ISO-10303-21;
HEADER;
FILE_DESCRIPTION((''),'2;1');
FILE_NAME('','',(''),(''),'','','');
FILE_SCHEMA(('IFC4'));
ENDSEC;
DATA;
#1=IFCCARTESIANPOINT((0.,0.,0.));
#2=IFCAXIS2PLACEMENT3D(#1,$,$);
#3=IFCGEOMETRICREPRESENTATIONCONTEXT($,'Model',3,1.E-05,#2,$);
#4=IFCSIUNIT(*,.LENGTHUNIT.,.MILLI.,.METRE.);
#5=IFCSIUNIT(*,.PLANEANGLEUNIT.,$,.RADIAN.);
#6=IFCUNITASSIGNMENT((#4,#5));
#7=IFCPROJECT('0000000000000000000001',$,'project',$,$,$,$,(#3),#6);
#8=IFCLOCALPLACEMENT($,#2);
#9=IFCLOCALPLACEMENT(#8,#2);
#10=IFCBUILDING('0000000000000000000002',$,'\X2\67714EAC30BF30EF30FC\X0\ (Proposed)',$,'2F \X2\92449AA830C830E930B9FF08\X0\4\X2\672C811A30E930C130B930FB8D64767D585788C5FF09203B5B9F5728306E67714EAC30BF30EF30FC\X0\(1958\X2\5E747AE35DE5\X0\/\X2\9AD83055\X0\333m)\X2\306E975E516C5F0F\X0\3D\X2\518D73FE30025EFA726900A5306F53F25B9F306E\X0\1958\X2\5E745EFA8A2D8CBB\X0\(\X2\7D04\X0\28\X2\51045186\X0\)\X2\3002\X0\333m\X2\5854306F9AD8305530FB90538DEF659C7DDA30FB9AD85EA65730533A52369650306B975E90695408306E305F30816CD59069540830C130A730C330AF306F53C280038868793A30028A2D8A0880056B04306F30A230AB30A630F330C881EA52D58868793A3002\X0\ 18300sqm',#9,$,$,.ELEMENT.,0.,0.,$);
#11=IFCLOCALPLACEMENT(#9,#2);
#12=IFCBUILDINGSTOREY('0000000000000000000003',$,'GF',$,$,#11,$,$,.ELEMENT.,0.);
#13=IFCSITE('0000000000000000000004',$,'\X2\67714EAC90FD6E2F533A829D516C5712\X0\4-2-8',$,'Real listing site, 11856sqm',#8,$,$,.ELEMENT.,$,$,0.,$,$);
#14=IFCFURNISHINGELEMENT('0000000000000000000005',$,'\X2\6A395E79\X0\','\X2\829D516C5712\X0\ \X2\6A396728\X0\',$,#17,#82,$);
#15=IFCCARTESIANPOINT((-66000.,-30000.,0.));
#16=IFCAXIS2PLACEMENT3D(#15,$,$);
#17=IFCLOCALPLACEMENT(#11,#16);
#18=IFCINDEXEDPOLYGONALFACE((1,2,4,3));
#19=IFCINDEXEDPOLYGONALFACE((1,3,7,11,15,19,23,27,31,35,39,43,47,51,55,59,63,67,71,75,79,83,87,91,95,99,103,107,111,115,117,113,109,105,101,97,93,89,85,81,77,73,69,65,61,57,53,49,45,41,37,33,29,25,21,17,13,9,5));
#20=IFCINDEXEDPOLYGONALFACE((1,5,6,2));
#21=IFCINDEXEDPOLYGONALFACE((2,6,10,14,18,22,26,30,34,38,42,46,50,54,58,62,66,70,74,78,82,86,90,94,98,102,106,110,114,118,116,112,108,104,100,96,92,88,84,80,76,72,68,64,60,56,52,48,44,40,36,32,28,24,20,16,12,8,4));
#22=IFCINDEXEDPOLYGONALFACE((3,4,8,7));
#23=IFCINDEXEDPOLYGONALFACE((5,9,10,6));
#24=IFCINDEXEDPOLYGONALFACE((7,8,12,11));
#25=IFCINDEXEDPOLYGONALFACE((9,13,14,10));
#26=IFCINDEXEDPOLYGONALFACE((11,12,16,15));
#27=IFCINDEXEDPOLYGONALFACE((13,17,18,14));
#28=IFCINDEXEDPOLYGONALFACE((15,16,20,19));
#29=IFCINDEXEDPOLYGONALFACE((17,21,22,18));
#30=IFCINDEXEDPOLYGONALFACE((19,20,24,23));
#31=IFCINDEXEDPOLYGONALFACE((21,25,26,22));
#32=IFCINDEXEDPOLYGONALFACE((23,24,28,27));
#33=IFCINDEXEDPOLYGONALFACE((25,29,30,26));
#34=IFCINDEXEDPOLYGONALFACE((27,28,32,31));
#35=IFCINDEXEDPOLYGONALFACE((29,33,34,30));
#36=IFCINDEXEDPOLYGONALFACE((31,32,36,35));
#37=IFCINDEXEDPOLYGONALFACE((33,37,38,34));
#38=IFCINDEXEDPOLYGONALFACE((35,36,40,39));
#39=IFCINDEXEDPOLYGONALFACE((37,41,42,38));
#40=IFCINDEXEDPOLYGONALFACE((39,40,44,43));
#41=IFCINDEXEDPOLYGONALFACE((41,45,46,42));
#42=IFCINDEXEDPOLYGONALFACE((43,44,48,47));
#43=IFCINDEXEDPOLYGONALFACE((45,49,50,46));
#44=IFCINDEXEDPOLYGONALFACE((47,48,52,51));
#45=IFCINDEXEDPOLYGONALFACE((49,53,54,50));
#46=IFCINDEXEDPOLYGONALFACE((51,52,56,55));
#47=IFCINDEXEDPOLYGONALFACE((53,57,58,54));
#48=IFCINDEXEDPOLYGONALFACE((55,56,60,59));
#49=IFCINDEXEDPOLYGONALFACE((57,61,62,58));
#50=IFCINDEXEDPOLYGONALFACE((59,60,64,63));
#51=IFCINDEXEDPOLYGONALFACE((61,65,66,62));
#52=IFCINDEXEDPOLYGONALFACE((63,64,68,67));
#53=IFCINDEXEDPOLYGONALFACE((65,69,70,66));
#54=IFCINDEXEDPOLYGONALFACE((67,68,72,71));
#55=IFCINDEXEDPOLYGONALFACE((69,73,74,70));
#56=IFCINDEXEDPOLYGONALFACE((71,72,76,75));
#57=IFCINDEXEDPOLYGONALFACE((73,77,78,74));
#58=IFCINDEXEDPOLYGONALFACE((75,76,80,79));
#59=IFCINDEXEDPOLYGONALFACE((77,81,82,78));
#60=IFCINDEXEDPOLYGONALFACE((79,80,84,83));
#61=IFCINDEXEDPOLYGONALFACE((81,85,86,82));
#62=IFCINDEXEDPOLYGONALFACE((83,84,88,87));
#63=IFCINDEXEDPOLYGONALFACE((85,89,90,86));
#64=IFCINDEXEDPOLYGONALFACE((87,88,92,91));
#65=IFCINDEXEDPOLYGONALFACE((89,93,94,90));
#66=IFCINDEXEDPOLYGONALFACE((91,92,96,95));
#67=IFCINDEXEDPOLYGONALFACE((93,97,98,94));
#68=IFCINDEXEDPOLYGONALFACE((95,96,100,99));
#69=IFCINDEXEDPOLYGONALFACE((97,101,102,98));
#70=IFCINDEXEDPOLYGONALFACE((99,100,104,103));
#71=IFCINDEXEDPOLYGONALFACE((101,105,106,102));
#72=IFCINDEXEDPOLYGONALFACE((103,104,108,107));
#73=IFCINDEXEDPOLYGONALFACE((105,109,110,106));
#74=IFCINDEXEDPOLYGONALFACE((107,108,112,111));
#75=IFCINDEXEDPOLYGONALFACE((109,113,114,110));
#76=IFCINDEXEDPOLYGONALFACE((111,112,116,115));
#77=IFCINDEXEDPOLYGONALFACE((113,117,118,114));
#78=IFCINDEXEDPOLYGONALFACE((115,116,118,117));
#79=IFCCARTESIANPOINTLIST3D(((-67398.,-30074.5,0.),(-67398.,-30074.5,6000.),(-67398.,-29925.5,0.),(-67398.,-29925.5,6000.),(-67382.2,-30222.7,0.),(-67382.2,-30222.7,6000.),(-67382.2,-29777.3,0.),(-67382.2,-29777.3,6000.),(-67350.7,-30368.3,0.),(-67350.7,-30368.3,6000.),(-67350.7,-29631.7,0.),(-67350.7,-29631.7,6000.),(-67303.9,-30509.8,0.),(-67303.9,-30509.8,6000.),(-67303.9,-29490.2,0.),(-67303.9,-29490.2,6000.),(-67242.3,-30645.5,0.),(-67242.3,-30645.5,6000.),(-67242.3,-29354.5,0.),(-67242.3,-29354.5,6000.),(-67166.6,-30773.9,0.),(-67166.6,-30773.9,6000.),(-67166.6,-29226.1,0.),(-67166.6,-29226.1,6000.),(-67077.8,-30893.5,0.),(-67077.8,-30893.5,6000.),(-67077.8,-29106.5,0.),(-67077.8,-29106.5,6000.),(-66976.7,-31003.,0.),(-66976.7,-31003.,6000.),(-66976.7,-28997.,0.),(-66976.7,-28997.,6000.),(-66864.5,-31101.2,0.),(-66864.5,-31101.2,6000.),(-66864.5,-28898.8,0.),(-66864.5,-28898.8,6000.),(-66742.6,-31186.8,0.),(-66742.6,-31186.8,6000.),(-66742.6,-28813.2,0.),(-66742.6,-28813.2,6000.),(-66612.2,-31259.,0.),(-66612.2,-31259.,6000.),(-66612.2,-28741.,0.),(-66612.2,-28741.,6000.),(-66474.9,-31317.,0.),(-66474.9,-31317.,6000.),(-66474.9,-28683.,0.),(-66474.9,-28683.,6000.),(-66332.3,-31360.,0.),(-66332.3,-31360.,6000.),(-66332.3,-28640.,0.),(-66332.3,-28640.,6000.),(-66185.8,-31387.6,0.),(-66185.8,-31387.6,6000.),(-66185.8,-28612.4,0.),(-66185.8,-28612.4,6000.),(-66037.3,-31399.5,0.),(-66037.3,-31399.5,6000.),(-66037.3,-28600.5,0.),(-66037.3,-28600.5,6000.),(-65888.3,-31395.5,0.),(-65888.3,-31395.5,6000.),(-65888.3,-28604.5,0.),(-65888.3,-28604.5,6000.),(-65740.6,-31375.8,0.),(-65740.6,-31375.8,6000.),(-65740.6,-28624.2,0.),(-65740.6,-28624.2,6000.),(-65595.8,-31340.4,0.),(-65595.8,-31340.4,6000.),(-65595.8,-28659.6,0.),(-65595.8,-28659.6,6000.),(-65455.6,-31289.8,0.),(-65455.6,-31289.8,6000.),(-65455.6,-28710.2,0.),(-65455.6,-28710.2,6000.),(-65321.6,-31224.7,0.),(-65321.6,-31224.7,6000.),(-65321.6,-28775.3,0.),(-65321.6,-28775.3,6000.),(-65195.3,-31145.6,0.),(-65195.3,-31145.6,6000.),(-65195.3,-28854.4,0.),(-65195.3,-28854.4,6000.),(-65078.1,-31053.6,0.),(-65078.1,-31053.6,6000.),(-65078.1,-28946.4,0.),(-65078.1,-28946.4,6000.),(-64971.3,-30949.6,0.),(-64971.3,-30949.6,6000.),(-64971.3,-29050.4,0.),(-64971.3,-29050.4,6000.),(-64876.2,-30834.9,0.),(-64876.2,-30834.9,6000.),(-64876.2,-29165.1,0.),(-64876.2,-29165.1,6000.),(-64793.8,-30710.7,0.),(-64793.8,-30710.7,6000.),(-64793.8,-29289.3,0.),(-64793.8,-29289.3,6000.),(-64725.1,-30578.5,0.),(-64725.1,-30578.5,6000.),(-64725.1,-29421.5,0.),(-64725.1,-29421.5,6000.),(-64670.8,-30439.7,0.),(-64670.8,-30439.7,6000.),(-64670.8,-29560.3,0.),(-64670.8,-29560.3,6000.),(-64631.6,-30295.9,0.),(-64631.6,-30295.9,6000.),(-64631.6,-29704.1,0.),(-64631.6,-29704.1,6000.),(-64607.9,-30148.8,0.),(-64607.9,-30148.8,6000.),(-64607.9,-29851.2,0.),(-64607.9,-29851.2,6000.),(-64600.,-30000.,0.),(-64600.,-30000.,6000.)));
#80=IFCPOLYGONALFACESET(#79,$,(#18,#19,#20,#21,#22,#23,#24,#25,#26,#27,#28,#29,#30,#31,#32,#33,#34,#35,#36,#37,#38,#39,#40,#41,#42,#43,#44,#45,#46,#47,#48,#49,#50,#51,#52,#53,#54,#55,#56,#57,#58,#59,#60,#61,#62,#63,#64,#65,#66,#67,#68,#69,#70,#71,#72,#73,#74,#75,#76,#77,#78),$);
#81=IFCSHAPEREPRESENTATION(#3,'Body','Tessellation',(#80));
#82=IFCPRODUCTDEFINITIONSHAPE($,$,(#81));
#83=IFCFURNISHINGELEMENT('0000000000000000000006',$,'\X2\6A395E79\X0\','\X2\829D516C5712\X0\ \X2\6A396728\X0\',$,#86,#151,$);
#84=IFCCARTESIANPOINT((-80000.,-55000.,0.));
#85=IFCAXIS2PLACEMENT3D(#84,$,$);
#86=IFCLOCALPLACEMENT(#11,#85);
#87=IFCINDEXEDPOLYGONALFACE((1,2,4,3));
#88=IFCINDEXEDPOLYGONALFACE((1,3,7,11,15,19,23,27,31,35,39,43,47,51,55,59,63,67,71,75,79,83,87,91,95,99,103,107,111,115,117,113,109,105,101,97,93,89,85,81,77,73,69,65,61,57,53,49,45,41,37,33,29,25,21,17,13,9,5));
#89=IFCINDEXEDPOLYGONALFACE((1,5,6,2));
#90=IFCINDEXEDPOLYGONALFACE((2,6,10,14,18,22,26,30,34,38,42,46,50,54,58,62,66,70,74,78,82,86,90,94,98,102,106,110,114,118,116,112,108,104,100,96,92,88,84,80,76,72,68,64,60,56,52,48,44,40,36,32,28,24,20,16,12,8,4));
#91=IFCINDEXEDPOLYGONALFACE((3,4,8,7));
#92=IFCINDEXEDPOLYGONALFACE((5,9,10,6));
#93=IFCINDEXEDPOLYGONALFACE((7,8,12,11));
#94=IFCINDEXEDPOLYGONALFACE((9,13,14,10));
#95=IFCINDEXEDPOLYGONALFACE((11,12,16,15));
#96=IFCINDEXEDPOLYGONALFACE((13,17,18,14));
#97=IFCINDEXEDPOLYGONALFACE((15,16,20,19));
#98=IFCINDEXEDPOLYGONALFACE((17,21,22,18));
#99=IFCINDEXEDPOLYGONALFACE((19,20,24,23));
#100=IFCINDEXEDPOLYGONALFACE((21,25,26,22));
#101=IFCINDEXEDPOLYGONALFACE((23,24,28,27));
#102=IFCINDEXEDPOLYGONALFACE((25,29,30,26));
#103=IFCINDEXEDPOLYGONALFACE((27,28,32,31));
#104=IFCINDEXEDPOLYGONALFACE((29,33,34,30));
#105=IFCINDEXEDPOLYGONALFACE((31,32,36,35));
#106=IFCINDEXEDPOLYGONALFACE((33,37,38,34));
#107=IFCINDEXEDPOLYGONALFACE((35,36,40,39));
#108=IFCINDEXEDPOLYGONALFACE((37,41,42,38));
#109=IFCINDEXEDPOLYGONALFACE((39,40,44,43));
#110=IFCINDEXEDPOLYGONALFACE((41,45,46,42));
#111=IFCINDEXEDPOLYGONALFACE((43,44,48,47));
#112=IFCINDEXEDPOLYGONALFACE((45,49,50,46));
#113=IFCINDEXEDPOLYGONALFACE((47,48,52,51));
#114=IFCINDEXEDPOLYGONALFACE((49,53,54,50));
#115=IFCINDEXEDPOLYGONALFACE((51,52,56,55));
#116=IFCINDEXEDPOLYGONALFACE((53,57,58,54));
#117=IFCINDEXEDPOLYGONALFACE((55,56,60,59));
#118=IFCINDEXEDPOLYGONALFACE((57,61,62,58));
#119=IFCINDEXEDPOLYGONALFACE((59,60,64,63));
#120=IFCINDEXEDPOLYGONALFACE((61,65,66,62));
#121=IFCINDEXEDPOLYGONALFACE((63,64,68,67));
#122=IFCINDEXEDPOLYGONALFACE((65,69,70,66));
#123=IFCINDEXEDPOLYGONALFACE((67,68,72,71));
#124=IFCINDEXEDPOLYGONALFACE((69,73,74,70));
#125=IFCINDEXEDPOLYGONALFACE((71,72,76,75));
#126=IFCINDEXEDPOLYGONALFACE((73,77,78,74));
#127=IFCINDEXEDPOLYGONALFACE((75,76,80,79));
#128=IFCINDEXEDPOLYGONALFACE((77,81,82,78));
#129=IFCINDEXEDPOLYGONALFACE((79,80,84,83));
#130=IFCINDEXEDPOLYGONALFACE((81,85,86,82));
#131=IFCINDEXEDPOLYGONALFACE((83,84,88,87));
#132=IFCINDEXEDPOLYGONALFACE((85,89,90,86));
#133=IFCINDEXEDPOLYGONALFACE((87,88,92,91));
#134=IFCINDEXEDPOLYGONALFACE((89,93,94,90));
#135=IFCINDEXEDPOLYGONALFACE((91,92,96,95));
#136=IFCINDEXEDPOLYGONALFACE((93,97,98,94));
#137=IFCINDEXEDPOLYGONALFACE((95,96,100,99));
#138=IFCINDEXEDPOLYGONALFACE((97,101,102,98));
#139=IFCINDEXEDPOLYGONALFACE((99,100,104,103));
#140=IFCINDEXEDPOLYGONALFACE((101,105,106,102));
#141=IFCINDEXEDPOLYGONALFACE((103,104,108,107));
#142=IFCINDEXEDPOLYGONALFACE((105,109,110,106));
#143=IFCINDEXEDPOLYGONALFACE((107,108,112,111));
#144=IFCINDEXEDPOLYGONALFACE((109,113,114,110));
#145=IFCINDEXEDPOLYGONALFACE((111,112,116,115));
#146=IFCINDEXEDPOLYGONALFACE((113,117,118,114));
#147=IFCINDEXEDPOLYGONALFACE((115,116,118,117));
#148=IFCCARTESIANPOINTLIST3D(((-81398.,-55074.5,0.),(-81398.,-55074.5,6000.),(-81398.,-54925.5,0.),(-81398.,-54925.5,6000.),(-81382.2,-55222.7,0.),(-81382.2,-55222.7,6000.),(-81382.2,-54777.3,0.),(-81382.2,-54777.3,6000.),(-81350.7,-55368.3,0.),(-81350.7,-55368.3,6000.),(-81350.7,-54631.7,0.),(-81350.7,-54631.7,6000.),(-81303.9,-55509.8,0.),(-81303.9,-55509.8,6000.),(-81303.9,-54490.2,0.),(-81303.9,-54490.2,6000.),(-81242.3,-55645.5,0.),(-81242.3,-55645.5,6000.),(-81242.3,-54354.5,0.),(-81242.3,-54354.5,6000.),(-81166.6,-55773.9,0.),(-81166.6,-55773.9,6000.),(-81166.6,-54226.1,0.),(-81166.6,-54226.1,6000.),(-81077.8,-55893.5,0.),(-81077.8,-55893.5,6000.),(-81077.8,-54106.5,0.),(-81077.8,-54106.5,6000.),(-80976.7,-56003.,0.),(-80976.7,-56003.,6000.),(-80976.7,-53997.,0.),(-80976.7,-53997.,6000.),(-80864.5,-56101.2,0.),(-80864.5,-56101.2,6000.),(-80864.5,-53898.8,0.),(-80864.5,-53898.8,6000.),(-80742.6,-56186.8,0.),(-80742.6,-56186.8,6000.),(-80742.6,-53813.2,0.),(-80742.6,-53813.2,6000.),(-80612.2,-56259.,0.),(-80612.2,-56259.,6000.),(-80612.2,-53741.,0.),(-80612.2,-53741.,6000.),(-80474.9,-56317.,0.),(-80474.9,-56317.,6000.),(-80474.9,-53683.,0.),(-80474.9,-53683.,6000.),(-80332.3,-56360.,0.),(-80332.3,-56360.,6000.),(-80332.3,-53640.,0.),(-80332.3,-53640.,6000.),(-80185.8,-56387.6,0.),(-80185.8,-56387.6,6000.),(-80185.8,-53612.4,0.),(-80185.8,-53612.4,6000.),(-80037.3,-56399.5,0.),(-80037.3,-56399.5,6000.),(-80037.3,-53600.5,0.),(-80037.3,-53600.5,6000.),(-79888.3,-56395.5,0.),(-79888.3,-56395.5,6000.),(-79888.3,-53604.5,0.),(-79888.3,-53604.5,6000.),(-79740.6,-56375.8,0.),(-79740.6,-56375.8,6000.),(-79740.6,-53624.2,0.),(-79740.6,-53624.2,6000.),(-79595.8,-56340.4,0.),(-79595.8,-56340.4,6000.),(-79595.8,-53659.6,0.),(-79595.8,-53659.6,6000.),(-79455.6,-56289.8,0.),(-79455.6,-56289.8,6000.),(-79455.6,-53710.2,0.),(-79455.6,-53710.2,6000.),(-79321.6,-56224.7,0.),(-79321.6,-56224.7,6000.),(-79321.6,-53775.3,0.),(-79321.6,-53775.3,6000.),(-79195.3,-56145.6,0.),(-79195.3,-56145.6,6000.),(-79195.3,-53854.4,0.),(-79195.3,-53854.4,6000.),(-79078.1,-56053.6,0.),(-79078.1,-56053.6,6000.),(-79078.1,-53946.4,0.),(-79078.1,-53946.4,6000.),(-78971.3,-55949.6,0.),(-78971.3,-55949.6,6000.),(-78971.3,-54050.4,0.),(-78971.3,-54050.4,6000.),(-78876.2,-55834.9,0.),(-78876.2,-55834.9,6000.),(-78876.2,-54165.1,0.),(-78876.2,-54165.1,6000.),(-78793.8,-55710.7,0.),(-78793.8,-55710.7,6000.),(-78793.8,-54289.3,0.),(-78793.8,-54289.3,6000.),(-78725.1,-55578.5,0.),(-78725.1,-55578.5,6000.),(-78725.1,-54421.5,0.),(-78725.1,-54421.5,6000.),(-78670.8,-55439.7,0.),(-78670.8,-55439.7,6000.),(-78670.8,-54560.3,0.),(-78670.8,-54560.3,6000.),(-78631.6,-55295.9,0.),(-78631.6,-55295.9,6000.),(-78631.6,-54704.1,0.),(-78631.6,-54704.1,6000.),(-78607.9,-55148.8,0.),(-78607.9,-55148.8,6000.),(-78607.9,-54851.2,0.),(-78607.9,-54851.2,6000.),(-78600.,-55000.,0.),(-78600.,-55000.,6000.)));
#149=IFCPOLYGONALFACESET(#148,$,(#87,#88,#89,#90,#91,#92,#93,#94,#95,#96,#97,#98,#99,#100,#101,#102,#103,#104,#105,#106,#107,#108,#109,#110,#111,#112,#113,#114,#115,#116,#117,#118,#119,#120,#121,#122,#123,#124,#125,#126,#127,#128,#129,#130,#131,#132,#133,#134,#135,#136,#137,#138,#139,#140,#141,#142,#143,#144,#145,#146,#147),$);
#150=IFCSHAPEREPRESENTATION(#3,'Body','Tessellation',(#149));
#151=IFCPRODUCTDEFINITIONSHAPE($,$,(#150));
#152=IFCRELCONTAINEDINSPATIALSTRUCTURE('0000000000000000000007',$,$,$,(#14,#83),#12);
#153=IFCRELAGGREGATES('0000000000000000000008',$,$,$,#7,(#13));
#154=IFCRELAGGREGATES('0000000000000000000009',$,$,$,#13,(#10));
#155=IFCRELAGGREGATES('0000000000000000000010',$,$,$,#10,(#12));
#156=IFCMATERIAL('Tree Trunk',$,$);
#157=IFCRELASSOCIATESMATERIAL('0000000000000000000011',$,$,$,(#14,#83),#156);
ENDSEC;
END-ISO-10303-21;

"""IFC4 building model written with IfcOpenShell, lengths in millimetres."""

from ifc_helpers import new_model, si_unit, frame, origin, origin_2d, place, context, project, spatial, circle, extrude, material, element, save


model = new_model("IFC4")

# Units and contexts
model_context = context("Model", 3, precision=1e-05, world=origin())
ifc_project = project(units=[si_unit("LENGTHUNIT", "METRE", prefix="MILLI"), si_unit("PLANEANGLEUNIT", "RADIAN")], contexts=[model_context])

# Site, building, storey
site_placement = place(None, origin())
site = spatial("IfcSite", under=ifc_project, at=site_placement, Name="東京都港区芝公園4-2-8", ObjectType="Real listing site, 11856sqm", CompositionType="ELEMENT", RefElevation=0.0)
building_placement = place(site_placement, origin())
building = spatial("IfcBuilding", under=site, at=building_placement, Name="東京タワー (Proposed)", ObjectType="2F 鉄骨トラス（4本脚ラチス・赤白塗装）※実在の東京タワー(1958年竣工/高さ333m)の非公式3D再現。建物¥は史実の1958年建設費(約28億円)。333m塔は高さ・道路斜線・高度地区制限に非適合のため法適合チェックは参考表示。設計者欄はアカウント自動表示。 18300sqm", CompositionType="ELEMENT", ElevationOfRefHeight=0.0, ElevationOfTerrain=0.0)
storey_placement = place(building_placement, origin())
storey = spatial("IfcBuildingStorey", under=building, at=storey_placement, Name="GF", CompositionType="ELEMENT", Elevation=0.0)

# Furnishing elements
ifc_material_1 = material(Name="Tree Trunk")
furnishing_1_placement = place(storey_placement, frame((-66000.0, -30000.0, 0.0)))
element("IfcFurnishingElement", 1, at=furnishing_1_placement, inside=storey, material=ifc_material_1, Name="樹幹", Description="芝公園 樹木", context=model_context, shape_type="SweptSolid", body=[
    extrude(circle(Radius=1400.0, at=origin_2d()), frame((-66000.0, -30000.0, 0.0)), (0.0, 0.0, 1.0), 6000.0),
])
furnishing_2_placement = place(storey_placement, frame((-80000.0, -55000.0, 0.0)))
element("IfcFurnishingElement", 2, at=furnishing_2_placement, inside=storey, material=ifc_material_1, Name="樹幹", Description="芝公園 樹木", context=model_context, shape_type="SweptSolid", body=[
    extrude(circle(Radius=1400.0, at=origin_2d()), frame((-80000.0, -55000.0, 0.0)), (0.0, 0.0, 1.0), 6000.0),
])

save(model, "model.ifc")
